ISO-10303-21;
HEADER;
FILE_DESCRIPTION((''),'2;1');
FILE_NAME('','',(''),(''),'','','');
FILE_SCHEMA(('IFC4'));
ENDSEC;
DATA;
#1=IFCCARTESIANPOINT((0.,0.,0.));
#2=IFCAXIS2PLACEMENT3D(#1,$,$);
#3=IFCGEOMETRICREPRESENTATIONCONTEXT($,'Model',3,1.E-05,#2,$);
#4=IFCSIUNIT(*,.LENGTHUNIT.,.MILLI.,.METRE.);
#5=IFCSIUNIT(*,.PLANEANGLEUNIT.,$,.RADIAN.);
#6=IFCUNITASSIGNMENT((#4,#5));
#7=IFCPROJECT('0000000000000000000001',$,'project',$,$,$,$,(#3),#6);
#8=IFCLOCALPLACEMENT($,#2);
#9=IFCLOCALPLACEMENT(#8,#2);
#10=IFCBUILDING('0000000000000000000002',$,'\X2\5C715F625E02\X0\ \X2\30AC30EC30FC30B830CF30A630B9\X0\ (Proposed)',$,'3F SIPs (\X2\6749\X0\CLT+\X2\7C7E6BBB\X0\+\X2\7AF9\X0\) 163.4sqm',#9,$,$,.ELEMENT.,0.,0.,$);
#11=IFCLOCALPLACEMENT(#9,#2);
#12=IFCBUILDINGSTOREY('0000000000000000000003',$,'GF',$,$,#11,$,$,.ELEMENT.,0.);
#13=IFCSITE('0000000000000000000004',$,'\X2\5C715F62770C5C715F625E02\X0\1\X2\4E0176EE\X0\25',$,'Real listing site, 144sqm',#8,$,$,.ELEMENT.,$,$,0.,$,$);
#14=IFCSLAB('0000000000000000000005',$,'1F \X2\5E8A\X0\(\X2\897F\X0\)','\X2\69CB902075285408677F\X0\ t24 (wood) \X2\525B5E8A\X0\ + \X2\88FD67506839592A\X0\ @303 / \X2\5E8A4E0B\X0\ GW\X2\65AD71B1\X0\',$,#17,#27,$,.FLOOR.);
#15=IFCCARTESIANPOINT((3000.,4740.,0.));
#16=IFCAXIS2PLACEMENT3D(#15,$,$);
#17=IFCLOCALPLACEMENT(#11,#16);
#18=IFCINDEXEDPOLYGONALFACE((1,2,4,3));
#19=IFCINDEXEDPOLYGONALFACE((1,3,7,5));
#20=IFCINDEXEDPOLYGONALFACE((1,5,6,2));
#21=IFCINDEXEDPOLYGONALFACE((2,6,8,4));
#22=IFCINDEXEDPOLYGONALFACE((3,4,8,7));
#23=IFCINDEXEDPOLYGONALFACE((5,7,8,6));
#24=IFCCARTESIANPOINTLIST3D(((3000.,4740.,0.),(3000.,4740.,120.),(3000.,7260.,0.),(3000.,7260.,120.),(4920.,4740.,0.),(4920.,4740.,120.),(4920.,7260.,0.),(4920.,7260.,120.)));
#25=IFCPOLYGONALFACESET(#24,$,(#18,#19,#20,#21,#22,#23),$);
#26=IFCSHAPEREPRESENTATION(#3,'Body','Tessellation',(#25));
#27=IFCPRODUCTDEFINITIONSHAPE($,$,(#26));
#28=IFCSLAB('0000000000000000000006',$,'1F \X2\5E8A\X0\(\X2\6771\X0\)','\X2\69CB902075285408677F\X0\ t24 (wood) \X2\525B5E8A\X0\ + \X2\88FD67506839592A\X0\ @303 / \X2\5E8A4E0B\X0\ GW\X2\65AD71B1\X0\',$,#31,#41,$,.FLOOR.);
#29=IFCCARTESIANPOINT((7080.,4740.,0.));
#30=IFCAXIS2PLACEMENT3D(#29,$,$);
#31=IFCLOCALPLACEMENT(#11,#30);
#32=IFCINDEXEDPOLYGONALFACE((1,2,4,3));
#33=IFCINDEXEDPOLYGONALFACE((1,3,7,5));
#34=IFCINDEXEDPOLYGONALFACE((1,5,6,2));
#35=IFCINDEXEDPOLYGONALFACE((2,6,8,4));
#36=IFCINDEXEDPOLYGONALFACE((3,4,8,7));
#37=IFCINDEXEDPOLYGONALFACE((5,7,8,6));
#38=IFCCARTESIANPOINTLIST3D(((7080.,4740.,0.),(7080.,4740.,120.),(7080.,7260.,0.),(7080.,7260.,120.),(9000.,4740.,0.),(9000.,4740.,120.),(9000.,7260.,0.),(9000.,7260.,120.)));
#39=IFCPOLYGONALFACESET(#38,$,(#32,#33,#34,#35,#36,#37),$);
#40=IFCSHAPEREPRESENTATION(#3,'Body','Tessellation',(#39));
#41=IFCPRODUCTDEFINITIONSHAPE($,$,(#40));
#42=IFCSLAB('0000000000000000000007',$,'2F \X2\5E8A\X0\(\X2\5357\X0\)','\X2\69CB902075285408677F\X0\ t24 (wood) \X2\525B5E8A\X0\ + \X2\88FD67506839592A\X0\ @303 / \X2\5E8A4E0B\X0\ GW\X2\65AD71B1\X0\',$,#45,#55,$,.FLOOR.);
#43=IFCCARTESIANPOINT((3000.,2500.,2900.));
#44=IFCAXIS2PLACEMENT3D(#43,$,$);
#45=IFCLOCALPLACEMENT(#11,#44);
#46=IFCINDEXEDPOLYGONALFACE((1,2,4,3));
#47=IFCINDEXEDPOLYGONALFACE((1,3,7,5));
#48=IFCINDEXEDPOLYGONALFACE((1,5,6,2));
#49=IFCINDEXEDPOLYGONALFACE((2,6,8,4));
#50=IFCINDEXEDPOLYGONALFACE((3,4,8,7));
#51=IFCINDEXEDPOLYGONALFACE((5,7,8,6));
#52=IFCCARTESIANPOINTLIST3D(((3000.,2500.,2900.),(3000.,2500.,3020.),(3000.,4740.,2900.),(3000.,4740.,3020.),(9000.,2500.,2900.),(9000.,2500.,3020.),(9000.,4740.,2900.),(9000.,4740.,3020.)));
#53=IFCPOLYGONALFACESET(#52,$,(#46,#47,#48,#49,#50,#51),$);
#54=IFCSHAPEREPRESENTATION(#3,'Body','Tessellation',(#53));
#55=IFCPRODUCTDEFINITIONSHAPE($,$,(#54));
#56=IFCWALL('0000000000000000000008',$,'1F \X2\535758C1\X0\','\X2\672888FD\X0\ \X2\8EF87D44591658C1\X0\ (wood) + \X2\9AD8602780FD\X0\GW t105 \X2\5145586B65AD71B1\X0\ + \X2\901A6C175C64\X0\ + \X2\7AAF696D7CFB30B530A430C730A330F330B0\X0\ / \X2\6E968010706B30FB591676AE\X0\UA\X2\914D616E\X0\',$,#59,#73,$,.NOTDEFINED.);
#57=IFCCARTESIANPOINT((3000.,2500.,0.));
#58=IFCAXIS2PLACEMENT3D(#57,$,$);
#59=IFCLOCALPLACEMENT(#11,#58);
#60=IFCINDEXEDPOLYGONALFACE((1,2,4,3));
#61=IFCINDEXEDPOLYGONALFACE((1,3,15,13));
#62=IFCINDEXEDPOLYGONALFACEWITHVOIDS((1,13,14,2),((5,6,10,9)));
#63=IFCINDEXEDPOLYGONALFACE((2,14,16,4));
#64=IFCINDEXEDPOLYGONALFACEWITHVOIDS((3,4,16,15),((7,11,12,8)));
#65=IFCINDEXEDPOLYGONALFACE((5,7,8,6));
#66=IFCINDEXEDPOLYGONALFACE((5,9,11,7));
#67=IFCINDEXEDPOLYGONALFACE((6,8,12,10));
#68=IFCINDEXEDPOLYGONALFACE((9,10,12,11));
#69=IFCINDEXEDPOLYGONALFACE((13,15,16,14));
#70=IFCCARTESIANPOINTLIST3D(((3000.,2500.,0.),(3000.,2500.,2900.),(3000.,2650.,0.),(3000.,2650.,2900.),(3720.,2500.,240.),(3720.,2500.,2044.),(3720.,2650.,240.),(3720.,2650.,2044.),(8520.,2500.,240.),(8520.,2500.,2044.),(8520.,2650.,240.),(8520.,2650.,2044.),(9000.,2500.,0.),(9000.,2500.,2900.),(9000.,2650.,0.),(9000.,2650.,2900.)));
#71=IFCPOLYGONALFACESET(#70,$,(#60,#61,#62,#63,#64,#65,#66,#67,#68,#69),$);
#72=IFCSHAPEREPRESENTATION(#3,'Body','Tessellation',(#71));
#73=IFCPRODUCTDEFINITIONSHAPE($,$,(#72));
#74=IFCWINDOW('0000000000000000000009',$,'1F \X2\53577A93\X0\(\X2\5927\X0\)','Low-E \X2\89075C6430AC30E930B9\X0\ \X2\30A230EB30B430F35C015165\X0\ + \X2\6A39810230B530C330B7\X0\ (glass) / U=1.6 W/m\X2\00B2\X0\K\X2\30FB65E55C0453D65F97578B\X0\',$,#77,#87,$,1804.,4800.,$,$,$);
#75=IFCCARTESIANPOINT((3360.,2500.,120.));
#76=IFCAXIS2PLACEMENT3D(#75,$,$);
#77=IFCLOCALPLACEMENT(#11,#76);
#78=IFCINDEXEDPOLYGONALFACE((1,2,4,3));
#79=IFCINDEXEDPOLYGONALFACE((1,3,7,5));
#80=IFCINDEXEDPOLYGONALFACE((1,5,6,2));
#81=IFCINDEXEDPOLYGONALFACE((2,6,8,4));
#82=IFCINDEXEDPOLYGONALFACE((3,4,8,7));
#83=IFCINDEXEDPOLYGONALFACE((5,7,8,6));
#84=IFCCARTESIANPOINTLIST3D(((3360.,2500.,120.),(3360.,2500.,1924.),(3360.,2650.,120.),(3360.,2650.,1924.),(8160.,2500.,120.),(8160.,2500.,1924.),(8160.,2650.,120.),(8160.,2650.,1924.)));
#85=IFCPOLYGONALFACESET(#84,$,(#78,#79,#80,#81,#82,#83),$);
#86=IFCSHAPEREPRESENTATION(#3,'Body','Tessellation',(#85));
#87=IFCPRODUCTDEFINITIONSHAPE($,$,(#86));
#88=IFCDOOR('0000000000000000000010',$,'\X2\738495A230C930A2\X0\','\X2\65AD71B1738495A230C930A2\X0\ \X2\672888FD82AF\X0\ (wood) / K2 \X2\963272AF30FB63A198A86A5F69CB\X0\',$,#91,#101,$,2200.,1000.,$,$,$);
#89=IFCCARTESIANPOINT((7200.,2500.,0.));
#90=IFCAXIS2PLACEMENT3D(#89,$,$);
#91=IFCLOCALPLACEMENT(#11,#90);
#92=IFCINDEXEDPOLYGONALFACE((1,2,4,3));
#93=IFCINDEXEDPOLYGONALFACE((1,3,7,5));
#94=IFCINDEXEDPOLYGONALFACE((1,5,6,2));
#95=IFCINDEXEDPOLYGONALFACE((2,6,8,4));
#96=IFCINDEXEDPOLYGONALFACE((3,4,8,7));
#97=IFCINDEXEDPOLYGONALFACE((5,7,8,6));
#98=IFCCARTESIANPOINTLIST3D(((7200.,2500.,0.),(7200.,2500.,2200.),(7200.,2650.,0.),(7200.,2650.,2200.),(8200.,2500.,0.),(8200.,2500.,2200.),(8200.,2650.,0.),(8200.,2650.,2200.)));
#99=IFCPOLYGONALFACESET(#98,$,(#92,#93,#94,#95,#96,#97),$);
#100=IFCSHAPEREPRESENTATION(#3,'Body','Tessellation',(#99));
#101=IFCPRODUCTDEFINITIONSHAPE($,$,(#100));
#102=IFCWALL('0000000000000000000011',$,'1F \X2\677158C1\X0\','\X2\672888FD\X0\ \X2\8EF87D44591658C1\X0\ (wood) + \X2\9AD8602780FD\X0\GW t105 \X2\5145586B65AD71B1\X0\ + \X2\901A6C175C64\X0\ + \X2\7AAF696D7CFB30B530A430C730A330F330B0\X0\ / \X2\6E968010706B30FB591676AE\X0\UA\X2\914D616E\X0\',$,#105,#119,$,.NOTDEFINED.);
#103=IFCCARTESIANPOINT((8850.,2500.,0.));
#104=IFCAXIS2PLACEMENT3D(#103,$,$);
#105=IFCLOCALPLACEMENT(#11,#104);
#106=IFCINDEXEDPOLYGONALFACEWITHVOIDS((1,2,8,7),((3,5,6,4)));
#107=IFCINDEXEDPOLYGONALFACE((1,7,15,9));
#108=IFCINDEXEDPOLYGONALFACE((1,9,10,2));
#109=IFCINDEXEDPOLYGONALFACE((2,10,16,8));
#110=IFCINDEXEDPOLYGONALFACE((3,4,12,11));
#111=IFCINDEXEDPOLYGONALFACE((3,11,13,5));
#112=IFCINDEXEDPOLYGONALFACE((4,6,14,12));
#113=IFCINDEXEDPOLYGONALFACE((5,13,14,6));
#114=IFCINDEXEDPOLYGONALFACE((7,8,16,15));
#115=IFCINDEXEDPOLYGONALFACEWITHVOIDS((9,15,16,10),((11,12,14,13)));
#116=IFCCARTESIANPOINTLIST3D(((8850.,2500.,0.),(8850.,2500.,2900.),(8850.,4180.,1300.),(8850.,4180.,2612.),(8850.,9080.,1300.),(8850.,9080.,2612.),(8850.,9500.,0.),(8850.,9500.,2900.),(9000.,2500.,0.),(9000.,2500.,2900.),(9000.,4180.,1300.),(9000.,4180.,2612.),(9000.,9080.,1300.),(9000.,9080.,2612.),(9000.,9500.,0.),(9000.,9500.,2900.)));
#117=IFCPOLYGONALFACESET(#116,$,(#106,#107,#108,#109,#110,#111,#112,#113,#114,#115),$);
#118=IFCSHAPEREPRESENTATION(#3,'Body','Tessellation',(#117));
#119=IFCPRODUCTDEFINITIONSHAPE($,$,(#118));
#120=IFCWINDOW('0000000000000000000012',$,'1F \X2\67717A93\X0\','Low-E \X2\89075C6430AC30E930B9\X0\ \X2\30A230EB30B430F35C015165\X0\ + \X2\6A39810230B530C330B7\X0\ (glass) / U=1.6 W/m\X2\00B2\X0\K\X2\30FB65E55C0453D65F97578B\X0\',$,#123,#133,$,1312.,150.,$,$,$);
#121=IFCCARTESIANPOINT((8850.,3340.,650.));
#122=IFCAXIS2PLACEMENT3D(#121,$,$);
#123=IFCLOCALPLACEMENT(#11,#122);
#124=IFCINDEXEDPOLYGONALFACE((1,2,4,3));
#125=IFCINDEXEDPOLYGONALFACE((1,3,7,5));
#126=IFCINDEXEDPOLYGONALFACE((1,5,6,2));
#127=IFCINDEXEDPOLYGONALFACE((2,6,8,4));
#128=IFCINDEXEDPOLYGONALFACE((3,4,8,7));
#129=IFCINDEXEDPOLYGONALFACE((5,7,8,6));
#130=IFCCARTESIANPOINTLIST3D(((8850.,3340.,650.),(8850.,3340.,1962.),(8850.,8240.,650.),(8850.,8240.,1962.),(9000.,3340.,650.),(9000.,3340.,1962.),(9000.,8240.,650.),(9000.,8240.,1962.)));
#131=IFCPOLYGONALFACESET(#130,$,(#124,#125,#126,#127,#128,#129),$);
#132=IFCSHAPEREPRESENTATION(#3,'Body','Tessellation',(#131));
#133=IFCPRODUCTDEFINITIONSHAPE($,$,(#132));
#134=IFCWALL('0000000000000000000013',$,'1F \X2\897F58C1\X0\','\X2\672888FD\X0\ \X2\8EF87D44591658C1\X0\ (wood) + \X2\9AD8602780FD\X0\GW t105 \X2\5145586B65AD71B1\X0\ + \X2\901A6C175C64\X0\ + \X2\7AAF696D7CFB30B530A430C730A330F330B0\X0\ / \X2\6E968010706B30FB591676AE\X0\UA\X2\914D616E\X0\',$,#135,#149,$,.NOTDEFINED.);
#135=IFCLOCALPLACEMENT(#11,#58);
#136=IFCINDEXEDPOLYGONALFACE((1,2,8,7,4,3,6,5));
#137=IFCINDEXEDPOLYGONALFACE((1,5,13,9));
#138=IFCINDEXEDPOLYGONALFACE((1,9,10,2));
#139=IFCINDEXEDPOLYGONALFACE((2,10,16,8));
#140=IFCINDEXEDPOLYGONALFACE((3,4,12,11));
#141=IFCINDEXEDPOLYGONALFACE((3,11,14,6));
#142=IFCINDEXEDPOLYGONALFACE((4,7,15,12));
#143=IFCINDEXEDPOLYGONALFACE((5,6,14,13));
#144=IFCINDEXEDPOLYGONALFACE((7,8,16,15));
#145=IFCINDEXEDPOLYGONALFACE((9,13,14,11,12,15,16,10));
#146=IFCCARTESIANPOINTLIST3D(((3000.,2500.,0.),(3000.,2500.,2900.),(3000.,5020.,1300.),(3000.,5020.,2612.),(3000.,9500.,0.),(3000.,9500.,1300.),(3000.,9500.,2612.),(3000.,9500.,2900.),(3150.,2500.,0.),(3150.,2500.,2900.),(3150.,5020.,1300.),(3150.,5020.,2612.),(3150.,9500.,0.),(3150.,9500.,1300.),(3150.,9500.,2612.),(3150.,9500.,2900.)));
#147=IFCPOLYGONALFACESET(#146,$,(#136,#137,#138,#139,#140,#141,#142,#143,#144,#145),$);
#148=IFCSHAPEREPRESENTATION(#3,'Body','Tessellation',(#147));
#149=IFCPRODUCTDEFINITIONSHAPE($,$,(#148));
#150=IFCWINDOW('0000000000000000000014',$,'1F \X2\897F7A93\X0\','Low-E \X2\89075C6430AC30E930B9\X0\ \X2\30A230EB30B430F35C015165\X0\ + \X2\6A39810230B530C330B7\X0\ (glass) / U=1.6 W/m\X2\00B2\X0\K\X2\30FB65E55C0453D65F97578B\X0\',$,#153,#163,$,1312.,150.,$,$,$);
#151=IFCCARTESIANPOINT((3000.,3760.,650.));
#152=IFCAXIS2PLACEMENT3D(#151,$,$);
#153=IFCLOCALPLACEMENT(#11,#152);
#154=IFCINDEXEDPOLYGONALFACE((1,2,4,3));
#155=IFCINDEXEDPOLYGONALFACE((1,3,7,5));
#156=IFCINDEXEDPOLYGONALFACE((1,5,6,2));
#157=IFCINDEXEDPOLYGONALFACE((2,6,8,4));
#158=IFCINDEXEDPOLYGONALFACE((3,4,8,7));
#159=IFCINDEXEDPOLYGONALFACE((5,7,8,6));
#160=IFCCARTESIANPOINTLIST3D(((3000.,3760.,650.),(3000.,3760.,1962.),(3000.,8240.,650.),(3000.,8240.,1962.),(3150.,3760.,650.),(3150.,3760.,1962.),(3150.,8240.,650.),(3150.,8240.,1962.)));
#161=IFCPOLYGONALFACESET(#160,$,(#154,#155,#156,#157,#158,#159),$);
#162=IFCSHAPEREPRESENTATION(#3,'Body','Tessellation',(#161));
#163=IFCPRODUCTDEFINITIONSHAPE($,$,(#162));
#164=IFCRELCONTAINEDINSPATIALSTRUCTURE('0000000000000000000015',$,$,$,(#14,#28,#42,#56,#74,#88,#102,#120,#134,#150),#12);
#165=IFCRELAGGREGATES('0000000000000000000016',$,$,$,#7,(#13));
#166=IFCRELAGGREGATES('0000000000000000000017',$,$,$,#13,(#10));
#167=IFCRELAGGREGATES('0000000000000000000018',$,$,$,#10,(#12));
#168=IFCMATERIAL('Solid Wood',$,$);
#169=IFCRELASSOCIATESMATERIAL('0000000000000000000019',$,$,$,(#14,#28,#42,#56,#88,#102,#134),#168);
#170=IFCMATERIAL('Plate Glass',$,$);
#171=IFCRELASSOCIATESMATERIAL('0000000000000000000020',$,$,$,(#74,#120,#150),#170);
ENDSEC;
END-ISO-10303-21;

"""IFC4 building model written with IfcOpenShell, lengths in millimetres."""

from ifc_helpers import new_model, si_unit, frame, frame_2d, origin, place, context, project, spatial, rectangle, extrude, material, element, fill, save


model = new_model("IFC4")

# Units and contexts
model_context = context("Model", 3, precision=1e-05, world=origin())
ifc_project = project(units=[si_unit("LENGTHUNIT", "METRE", prefix="MILLI"), si_unit("PLANEANGLEUNIT", "RADIAN")], contexts=[model_context])

# Site, building, storey
site_placement = place(None, origin())
site = spatial("IfcSite", under=ifc_project, at=site_placement, Name="山形県山形市1丁目25", ObjectType="Real listing site, 144sqm", CompositionType="ELEMENT", RefElevation=0.0)
building_placement = place(site_placement, origin())
building = spatial("IfcBuilding", under=site, at=building_placement, Name="山形市 ガレージハウス (Proposed)", ObjectType="3F SIPs (杉CLT+籾殻+竹) 163.4sqm", CompositionType="ELEMENT", ElevationOfRefHeight=0.0, ElevationOfTerrain=0.0)
storey_placement = place(building_placement, origin())
storey = spatial("IfcBuildingStorey", under=building, at=storey_placement, Name="GF", CompositionType="ELEMENT", Elevation=0.0)

# Slabs
ifc_material_1 = material(Name="Solid Wood")
slab_1_placement = place(storey_placement, frame((3000.0, 4740.0, 0.0)))
element("IfcSlab", 1, at=slab_1_placement, inside=storey, material=ifc_material_1, Name="1F 床(西)", Description="構造用合板 t24 (wood) 剛床 + 製材根太 @303 / 床下 GW断熱", PredefinedType="FLOOR", context=model_context, shape_type="SweptSolid", body=[
    extrude(rectangle(XDim=1920.0, YDim=2520.0, at=frame_2d((960.0, 1260.0))), frame((3000.0, 4740.0, 0.0)), (0.0, 0.0, 1.0), 120.0),
])
slab_2_placement = place(storey_placement, frame((7080.0, 4740.0, 0.0)))
element("IfcSlab", 2, at=slab_2_placement, inside=storey, material=ifc_material_1, Name="1F 床(東)", Description="構造用合板 t24 (wood) 剛床 + 製材根太 @303 / 床下 GW断熱", PredefinedType="FLOOR", context=model_context, shape_type="SweptSolid", body=[
    extrude(rectangle(XDim=1920.0, YDim=2520.0, at=frame_2d((960.0, 1260.0))), frame((7080.0, 4740.0, 0.0)), (0.0, 0.0, 1.0), 120.0),
])
slab_3_placement = place(storey_placement, frame((3000.0, 2500.0, 2900.0)))
element("IfcSlab", 3, at=slab_3_placement, inside=storey, material=ifc_material_1, Name="2F 床(南)", Description="構造用合板 t24 (wood) 剛床 + 製材根太 @303 / 床下 GW断熱", PredefinedType="FLOOR", context=model_context, shape_type="SweptSolid", body=[
    extrude(rectangle(XDim=6000.0, YDim=2240.0, at=frame_2d((3000.0, 1120.0))), frame((3000.0, 2500.0, 2900.0)), (0.0, 0.0, 1.0), 120.0),
])

# Wall, openings, window, door
wall_1_placement = place(storey_placement, frame((3000.0, 2500.0, 0.0)))
wall_1 = element("IfcWall", 4, at=wall_1_placement, inside=storey, material=ifc_material_1, Name="1F 南壁", Description="木製 軸組外壁 (wood) + 高性能GW t105 充填断熱 + 通気層 + 窯業系サイディング / 準耐火・外皮UA配慮", PredefinedType="NOTDEFINED", context=model_context, shape_type="SweptSolid", body=[
    extrude(rectangle(XDim=6000.0, YDim=150.0, at=frame_2d((3000.0, 75.0))), frame((3000.0, 2500.0, 0.0)), (0.0, 0.0, 1.0), 2900.0),
])
opening_1_placement = place(storey_placement, frame((3360.0, 2500.0, 120.0)))
opening_1 = element("IfcOpeningElement", 5, at=opening_1_placement, cuts=wall_1, PredefinedType="NOTDEFINED", context=model_context, shape_type="SweptSolid", body=[
    extrude(rectangle(XDim=4800.0, YDim=150.0, at=frame_2d((2400.0, 75.0))), frame((3360.0, 2500.0, 120.0)), (0.0, 0.0, 1.0), 1804.0),
])
opening_2_placement = place(storey_placement, frame((7200.0, 2500.0, 0.0)))
opening_2 = element("IfcOpeningElement", 6, at=opening_2_placement, cuts=wall_1, PredefinedType="NOTDEFINED", context=model_context, shape_type="SweptSolid", body=[
    extrude(rectangle(XDim=1000.0, YDim=150.0, at=frame_2d((500.0, 75.0))), frame((7200.0, 2500.0, 0.0)), (0.0, 0.0, 1.0), 2200.0),
])
ifc_material_2 = material(Name="Plate Glass")
window_1_placement = place(storey_placement, frame((3360.0, 2500.0, 120.0)))
window_1 = element("IfcWindow", 7, at=window_1_placement, inside=storey, material=ifc_material_2, Name="1F 南窓(大)", Description="Low-E 複層ガラス アルゴン封入 + 樹脂サッシ (glass) / U=1.6 W/m²K・日射取得型", OverallHeight=1804.0, OverallWidth=4800.0, context=model_context, shape_type="SweptSolid", body=[
    extrude(rectangle(XDim=4800.0, YDim=150.0, at=frame_2d((2400.0, 75.0))), frame((3360.0, 2500.0, 120.0)), (0.0, 0.0, 1.0), 1804.0),
])
fill(opening_1, window_1)
door_placement = place(storey_placement, frame((7200.0, 2500.0, 0.0)))
door = element("IfcDoor", 8, at=door_placement, inside=storey, material=ifc_material_1, Name="玄関ドア", Description="断熱玄関ドア 木製芯 (wood) / K2 防犯・採風機構", OverallHeight=2200.0, OverallWidth=1000.0, context=model_context, shape_type="SweptSolid", body=[
    extrude(rectangle(XDim=1000.0, YDim=150.0, at=frame_2d((500.0, 75.0))), frame((7200.0, 2500.0, 0.0)), (0.0, 0.0, 1.0), 2200.0),
])
fill(opening_2, door)

# Walls, openings, windows
wall_2_placement = place(storey_placement, frame((8850.0, 2500.0, 0.0)))
wall_2 = element("IfcWall", 9, at=wall_2_placement, inside=storey, material=ifc_material_1, Name="1F 東壁", Description="木製 軸組外壁 (wood) + 高性能GW t105 充填断熱 + 通気層 + 窯業系サイディング / 準耐火・外皮UA配慮", PredefinedType="NOTDEFINED", context=model_context, shape_type="SweptSolid", body=[
    extrude(rectangle(XDim=150.0, YDim=7000.0, at=frame_2d((75.0, 3500.0))), frame((8850.0, 2500.0, 0.0)), (0.0, 0.0, 1.0), 2900.0),
])
opening_3_placement = place(storey_placement, frame((8850.0, 3340.0, 650.0)))
opening_3 = element("IfcOpeningElement", 10, at=opening_3_placement, cuts=wall_2, PredefinedType="NOTDEFINED", context=model_context, shape_type="SweptSolid", body=[
    extrude(rectangle(XDim=150.0, YDim=4900.0, at=frame_2d((75.0, 2450.0))), frame((8850.0, 3340.0, 650.0)), (0.0, 0.0, 1.0), 1312.0),
])
window_2_placement = place(storey_placement, frame((8850.0, 3340.0, 650.0)))
window_2 = element("IfcWindow", 11, at=window_2_placement, inside=storey, material=ifc_material_2, Name="1F 東窓", Description="Low-E 複層ガラス アルゴン封入 + 樹脂サッシ (glass) / U=1.6 W/m²K・日射取得型", OverallHeight=1312.0, OverallWidth=150.0, context=model_context, shape_type="SweptSolid", body=[
    extrude(rectangle(XDim=150.0, YDim=4900.0, at=frame_2d((75.0, 2450.0))), frame((8850.0, 3340.0, 650.0)), (0.0, 0.0, 1.0), 1312.0),
])
fill(opening_3, window_2)
wall_3_placement = place(storey_placement, frame((3000.0, 2500.0, 0.0)))
wall_3 = element("IfcWall", 12, at=wall_3_placement, inside=storey, material=ifc_material_1, Name="1F 西壁", Description="木製 軸組外壁 (wood) + 高性能GW t105 充填断熱 + 通気層 + 窯業系サイディング / 準耐火・外皮UA配慮", PredefinedType="NOTDEFINED", context=model_context, shape_type="SweptSolid", body=[
    extrude(rectangle(XDim=150.0, YDim=7000.0, at=frame_2d((75.0, 3500.0))), frame((3000.0, 2500.0, 0.0)), (0.0, 0.0, 1.0), 2900.0),
])
opening_4_placement = place(storey_placement, frame((3000.0, 3760.0, 650.0)))
opening_4 = element("IfcOpeningElement", 13, at=opening_4_placement, cuts=wall_3, PredefinedType="NOTDEFINED", context=model_context, shape_type="SweptSolid", body=[
    extrude(rectangle(XDim=150.0, YDim=4480.0, at=frame_2d((75.0, 2240.0))), frame((3000.0, 3760.0, 650.0)), (0.0, 0.0, 1.0), 1312.0),
])
window_3_placement = place(storey_placement, frame((3000.0, 3760.0, 650.0)))
window_3 = element("IfcWindow", 14, at=window_3_placement, inside=storey, material=ifc_material_2, Name="1F 西窓", Description="Low-E 複層ガラス アルゴン封入 + 樹脂サッシ (glass) / U=1.6 W/m²K・日射取得型", OverallHeight=1312.0, OverallWidth=150.0, context=model_context, shape_type="SweptSolid", body=[
    extrude(rectangle(XDim=150.0, YDim=4480.0, at=frame_2d((75.0, 2240.0))), frame((3000.0, 3760.0, 650.0)), (0.0, 0.0, 1.0), 1312.0),
])
fill(opening_4, window_3)

save(model, "model.ifc")
